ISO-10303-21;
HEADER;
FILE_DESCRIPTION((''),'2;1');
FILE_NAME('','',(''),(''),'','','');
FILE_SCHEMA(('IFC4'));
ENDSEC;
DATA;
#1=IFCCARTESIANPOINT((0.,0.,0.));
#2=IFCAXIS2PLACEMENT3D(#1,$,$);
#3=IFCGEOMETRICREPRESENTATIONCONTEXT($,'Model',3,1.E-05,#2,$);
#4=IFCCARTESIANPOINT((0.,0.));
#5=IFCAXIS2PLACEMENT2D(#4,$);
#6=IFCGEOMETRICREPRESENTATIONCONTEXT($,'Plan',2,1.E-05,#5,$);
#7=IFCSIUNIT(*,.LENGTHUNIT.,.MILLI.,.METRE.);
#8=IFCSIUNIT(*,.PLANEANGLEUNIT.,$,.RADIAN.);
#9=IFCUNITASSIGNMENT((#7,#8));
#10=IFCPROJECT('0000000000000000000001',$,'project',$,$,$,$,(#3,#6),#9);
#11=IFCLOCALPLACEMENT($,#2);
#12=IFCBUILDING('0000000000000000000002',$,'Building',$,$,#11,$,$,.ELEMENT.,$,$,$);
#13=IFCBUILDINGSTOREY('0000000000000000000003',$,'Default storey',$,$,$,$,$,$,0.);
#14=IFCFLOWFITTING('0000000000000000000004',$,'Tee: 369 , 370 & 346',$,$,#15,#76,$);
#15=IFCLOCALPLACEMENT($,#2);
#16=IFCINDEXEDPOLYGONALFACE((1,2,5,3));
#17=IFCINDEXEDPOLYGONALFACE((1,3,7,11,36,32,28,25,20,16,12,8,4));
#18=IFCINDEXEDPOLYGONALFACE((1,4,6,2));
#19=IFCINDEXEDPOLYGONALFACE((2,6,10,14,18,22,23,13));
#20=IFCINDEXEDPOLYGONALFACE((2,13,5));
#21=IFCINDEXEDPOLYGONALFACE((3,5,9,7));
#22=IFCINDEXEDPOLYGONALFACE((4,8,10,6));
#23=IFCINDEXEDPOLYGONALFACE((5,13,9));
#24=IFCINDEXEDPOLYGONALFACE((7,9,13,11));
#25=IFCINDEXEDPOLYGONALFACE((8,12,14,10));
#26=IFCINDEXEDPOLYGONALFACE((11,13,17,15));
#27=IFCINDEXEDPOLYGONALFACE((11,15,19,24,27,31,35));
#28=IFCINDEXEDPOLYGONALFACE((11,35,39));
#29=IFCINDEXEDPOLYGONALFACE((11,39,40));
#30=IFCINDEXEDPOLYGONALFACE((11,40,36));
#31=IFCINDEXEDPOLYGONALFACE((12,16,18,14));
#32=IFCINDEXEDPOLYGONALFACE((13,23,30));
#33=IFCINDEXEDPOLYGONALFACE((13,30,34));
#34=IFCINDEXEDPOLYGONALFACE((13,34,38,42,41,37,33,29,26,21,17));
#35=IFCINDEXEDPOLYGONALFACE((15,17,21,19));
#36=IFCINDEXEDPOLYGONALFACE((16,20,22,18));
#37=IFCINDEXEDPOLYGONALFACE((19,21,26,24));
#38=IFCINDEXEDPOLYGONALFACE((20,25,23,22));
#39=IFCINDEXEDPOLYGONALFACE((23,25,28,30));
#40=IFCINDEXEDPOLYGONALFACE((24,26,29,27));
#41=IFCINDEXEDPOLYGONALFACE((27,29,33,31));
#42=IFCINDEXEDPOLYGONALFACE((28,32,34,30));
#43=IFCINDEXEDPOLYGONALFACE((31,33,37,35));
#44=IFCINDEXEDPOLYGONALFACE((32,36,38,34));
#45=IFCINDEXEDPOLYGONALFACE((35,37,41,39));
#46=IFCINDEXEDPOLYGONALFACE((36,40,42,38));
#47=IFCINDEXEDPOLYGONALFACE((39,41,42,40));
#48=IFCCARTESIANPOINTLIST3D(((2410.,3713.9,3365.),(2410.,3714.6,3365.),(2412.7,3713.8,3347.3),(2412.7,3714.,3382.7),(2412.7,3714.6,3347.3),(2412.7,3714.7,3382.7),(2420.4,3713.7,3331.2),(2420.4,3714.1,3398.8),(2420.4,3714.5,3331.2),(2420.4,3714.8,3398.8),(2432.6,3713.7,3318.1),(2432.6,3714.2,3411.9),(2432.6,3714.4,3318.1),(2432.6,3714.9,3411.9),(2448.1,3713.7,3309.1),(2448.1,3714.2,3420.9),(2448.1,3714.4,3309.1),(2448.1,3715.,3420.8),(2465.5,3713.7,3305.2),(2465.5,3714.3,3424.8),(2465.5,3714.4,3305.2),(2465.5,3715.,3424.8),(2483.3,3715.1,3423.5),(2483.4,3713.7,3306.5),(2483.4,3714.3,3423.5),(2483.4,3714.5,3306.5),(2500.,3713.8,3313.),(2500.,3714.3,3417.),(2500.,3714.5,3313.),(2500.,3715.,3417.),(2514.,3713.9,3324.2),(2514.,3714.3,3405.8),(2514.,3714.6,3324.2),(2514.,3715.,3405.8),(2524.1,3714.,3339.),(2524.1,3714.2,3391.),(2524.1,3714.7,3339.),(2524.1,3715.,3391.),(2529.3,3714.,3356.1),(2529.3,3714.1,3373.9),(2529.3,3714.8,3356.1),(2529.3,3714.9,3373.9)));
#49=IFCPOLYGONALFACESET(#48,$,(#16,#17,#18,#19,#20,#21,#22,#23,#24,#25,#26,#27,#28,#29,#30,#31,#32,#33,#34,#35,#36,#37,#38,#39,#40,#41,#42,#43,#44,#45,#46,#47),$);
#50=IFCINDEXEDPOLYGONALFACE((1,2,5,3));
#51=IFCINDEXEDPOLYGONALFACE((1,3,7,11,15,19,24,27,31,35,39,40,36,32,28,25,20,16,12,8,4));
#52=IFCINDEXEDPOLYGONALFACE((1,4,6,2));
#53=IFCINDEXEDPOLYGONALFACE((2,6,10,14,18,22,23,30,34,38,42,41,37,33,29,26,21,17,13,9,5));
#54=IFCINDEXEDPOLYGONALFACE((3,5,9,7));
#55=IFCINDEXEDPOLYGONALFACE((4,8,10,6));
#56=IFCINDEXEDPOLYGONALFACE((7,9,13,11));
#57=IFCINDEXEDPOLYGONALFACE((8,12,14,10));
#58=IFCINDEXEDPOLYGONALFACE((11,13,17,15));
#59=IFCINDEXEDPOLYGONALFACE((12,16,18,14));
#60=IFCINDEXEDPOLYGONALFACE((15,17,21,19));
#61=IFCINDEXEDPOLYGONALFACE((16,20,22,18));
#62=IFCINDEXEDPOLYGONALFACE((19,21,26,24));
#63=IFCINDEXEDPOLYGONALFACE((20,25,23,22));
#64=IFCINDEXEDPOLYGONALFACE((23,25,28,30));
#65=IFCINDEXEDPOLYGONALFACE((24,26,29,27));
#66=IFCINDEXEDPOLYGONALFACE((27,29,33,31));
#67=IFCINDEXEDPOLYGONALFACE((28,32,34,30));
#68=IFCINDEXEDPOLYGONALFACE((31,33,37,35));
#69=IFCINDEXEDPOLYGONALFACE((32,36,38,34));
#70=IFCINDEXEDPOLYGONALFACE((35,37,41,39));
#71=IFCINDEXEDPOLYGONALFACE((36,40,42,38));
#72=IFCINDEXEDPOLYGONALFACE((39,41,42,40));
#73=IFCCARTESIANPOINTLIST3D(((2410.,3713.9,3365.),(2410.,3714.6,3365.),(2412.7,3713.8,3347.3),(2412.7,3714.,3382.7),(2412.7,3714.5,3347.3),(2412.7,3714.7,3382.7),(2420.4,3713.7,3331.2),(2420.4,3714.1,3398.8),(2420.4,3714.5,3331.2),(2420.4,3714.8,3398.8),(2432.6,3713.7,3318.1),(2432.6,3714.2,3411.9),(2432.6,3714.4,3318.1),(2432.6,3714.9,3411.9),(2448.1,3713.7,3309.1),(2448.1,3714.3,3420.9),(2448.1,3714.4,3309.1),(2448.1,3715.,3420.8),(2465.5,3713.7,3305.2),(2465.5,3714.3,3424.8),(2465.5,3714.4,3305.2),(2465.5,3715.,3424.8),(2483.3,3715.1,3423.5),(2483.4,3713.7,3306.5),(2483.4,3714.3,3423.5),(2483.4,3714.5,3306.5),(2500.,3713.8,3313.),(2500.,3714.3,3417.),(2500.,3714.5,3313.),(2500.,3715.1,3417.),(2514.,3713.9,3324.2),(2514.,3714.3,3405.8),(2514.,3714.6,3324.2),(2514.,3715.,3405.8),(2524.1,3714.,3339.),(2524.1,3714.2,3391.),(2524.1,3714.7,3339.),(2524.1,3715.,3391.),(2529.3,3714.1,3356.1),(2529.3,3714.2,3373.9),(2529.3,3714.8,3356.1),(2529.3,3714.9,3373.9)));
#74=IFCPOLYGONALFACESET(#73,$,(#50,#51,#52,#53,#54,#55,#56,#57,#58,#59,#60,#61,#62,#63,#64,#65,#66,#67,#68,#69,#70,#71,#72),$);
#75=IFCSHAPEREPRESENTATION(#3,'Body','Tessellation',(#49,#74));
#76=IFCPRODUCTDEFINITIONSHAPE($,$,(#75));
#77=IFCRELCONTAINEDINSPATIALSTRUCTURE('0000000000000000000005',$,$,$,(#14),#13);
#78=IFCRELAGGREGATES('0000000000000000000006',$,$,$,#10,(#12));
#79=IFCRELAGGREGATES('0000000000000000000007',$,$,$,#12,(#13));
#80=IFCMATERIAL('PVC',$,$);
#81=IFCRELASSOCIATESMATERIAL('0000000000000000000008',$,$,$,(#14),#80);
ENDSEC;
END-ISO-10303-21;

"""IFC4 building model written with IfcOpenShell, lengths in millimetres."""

from ifc_helpers import new_model, si_unit, frame, origin, origin_2d, place, context, project, spatial, circle, extrude, material, element, save


model = new_model("IFC4")

# Units and contexts
model_context = context("Model", 3, precision=1e-05, world=origin())
plan_context = context("Plan", 2, precision=1e-05, world=origin_2d())
ifc_project = project(units=[si_unit("LENGTHUNIT", "METRE", prefix="MILLI"), si_unit("PLANEANGLEUNIT", "RADIAN")], contexts=[model_context, plan_context])

# Building, storey
placement = place(None, origin())
building = spatial("IfcBuilding", under=ifc_project, at=placement, Name="Building", CompositionType="ELEMENT")
storey = spatial("IfcBuildingStorey", under=building, Name="Default storey", Elevation=0.0)

# Flow fitting
ifc_material = material(Name="PVC")
element("IfcFlowFitting", 1, at=placement, inside=storey, material=ifc_material, Name="Tee: 369 , 370 & 346", context=model_context, body=[
    extrude(circle(Radius=60.0, at=origin_2d()), frame((2470.0, 3714.7, 3365.0), z_axis=(0.001168, -0.73259, 0.003737), x_axis=(-732.589541, -1.167659, 0.0)), (0.0, 0.0, 1.0), 0.7),
    extrude(circle(Radius=60.0, at=origin_2d()), frame((2470.0, 3714.7, 3365.0), z_axis=(0.001298, -0.732589, 0.003795), x_axis=(-732.589022, -1.298208, 0.0)), (0.0, 0.0, 1.0), 0.7),
    extrude(circle(Radius=58.0, at=origin_2d()), frame((2470.0, 3714.0, 3364.3), z_axis=(0.0, 0.0, 0.7326), x_axis=(0.0, 0.0, 0.0)), (0.0, 0.0, 1.0), 0.7),
])

save(model, "model.ifc")
